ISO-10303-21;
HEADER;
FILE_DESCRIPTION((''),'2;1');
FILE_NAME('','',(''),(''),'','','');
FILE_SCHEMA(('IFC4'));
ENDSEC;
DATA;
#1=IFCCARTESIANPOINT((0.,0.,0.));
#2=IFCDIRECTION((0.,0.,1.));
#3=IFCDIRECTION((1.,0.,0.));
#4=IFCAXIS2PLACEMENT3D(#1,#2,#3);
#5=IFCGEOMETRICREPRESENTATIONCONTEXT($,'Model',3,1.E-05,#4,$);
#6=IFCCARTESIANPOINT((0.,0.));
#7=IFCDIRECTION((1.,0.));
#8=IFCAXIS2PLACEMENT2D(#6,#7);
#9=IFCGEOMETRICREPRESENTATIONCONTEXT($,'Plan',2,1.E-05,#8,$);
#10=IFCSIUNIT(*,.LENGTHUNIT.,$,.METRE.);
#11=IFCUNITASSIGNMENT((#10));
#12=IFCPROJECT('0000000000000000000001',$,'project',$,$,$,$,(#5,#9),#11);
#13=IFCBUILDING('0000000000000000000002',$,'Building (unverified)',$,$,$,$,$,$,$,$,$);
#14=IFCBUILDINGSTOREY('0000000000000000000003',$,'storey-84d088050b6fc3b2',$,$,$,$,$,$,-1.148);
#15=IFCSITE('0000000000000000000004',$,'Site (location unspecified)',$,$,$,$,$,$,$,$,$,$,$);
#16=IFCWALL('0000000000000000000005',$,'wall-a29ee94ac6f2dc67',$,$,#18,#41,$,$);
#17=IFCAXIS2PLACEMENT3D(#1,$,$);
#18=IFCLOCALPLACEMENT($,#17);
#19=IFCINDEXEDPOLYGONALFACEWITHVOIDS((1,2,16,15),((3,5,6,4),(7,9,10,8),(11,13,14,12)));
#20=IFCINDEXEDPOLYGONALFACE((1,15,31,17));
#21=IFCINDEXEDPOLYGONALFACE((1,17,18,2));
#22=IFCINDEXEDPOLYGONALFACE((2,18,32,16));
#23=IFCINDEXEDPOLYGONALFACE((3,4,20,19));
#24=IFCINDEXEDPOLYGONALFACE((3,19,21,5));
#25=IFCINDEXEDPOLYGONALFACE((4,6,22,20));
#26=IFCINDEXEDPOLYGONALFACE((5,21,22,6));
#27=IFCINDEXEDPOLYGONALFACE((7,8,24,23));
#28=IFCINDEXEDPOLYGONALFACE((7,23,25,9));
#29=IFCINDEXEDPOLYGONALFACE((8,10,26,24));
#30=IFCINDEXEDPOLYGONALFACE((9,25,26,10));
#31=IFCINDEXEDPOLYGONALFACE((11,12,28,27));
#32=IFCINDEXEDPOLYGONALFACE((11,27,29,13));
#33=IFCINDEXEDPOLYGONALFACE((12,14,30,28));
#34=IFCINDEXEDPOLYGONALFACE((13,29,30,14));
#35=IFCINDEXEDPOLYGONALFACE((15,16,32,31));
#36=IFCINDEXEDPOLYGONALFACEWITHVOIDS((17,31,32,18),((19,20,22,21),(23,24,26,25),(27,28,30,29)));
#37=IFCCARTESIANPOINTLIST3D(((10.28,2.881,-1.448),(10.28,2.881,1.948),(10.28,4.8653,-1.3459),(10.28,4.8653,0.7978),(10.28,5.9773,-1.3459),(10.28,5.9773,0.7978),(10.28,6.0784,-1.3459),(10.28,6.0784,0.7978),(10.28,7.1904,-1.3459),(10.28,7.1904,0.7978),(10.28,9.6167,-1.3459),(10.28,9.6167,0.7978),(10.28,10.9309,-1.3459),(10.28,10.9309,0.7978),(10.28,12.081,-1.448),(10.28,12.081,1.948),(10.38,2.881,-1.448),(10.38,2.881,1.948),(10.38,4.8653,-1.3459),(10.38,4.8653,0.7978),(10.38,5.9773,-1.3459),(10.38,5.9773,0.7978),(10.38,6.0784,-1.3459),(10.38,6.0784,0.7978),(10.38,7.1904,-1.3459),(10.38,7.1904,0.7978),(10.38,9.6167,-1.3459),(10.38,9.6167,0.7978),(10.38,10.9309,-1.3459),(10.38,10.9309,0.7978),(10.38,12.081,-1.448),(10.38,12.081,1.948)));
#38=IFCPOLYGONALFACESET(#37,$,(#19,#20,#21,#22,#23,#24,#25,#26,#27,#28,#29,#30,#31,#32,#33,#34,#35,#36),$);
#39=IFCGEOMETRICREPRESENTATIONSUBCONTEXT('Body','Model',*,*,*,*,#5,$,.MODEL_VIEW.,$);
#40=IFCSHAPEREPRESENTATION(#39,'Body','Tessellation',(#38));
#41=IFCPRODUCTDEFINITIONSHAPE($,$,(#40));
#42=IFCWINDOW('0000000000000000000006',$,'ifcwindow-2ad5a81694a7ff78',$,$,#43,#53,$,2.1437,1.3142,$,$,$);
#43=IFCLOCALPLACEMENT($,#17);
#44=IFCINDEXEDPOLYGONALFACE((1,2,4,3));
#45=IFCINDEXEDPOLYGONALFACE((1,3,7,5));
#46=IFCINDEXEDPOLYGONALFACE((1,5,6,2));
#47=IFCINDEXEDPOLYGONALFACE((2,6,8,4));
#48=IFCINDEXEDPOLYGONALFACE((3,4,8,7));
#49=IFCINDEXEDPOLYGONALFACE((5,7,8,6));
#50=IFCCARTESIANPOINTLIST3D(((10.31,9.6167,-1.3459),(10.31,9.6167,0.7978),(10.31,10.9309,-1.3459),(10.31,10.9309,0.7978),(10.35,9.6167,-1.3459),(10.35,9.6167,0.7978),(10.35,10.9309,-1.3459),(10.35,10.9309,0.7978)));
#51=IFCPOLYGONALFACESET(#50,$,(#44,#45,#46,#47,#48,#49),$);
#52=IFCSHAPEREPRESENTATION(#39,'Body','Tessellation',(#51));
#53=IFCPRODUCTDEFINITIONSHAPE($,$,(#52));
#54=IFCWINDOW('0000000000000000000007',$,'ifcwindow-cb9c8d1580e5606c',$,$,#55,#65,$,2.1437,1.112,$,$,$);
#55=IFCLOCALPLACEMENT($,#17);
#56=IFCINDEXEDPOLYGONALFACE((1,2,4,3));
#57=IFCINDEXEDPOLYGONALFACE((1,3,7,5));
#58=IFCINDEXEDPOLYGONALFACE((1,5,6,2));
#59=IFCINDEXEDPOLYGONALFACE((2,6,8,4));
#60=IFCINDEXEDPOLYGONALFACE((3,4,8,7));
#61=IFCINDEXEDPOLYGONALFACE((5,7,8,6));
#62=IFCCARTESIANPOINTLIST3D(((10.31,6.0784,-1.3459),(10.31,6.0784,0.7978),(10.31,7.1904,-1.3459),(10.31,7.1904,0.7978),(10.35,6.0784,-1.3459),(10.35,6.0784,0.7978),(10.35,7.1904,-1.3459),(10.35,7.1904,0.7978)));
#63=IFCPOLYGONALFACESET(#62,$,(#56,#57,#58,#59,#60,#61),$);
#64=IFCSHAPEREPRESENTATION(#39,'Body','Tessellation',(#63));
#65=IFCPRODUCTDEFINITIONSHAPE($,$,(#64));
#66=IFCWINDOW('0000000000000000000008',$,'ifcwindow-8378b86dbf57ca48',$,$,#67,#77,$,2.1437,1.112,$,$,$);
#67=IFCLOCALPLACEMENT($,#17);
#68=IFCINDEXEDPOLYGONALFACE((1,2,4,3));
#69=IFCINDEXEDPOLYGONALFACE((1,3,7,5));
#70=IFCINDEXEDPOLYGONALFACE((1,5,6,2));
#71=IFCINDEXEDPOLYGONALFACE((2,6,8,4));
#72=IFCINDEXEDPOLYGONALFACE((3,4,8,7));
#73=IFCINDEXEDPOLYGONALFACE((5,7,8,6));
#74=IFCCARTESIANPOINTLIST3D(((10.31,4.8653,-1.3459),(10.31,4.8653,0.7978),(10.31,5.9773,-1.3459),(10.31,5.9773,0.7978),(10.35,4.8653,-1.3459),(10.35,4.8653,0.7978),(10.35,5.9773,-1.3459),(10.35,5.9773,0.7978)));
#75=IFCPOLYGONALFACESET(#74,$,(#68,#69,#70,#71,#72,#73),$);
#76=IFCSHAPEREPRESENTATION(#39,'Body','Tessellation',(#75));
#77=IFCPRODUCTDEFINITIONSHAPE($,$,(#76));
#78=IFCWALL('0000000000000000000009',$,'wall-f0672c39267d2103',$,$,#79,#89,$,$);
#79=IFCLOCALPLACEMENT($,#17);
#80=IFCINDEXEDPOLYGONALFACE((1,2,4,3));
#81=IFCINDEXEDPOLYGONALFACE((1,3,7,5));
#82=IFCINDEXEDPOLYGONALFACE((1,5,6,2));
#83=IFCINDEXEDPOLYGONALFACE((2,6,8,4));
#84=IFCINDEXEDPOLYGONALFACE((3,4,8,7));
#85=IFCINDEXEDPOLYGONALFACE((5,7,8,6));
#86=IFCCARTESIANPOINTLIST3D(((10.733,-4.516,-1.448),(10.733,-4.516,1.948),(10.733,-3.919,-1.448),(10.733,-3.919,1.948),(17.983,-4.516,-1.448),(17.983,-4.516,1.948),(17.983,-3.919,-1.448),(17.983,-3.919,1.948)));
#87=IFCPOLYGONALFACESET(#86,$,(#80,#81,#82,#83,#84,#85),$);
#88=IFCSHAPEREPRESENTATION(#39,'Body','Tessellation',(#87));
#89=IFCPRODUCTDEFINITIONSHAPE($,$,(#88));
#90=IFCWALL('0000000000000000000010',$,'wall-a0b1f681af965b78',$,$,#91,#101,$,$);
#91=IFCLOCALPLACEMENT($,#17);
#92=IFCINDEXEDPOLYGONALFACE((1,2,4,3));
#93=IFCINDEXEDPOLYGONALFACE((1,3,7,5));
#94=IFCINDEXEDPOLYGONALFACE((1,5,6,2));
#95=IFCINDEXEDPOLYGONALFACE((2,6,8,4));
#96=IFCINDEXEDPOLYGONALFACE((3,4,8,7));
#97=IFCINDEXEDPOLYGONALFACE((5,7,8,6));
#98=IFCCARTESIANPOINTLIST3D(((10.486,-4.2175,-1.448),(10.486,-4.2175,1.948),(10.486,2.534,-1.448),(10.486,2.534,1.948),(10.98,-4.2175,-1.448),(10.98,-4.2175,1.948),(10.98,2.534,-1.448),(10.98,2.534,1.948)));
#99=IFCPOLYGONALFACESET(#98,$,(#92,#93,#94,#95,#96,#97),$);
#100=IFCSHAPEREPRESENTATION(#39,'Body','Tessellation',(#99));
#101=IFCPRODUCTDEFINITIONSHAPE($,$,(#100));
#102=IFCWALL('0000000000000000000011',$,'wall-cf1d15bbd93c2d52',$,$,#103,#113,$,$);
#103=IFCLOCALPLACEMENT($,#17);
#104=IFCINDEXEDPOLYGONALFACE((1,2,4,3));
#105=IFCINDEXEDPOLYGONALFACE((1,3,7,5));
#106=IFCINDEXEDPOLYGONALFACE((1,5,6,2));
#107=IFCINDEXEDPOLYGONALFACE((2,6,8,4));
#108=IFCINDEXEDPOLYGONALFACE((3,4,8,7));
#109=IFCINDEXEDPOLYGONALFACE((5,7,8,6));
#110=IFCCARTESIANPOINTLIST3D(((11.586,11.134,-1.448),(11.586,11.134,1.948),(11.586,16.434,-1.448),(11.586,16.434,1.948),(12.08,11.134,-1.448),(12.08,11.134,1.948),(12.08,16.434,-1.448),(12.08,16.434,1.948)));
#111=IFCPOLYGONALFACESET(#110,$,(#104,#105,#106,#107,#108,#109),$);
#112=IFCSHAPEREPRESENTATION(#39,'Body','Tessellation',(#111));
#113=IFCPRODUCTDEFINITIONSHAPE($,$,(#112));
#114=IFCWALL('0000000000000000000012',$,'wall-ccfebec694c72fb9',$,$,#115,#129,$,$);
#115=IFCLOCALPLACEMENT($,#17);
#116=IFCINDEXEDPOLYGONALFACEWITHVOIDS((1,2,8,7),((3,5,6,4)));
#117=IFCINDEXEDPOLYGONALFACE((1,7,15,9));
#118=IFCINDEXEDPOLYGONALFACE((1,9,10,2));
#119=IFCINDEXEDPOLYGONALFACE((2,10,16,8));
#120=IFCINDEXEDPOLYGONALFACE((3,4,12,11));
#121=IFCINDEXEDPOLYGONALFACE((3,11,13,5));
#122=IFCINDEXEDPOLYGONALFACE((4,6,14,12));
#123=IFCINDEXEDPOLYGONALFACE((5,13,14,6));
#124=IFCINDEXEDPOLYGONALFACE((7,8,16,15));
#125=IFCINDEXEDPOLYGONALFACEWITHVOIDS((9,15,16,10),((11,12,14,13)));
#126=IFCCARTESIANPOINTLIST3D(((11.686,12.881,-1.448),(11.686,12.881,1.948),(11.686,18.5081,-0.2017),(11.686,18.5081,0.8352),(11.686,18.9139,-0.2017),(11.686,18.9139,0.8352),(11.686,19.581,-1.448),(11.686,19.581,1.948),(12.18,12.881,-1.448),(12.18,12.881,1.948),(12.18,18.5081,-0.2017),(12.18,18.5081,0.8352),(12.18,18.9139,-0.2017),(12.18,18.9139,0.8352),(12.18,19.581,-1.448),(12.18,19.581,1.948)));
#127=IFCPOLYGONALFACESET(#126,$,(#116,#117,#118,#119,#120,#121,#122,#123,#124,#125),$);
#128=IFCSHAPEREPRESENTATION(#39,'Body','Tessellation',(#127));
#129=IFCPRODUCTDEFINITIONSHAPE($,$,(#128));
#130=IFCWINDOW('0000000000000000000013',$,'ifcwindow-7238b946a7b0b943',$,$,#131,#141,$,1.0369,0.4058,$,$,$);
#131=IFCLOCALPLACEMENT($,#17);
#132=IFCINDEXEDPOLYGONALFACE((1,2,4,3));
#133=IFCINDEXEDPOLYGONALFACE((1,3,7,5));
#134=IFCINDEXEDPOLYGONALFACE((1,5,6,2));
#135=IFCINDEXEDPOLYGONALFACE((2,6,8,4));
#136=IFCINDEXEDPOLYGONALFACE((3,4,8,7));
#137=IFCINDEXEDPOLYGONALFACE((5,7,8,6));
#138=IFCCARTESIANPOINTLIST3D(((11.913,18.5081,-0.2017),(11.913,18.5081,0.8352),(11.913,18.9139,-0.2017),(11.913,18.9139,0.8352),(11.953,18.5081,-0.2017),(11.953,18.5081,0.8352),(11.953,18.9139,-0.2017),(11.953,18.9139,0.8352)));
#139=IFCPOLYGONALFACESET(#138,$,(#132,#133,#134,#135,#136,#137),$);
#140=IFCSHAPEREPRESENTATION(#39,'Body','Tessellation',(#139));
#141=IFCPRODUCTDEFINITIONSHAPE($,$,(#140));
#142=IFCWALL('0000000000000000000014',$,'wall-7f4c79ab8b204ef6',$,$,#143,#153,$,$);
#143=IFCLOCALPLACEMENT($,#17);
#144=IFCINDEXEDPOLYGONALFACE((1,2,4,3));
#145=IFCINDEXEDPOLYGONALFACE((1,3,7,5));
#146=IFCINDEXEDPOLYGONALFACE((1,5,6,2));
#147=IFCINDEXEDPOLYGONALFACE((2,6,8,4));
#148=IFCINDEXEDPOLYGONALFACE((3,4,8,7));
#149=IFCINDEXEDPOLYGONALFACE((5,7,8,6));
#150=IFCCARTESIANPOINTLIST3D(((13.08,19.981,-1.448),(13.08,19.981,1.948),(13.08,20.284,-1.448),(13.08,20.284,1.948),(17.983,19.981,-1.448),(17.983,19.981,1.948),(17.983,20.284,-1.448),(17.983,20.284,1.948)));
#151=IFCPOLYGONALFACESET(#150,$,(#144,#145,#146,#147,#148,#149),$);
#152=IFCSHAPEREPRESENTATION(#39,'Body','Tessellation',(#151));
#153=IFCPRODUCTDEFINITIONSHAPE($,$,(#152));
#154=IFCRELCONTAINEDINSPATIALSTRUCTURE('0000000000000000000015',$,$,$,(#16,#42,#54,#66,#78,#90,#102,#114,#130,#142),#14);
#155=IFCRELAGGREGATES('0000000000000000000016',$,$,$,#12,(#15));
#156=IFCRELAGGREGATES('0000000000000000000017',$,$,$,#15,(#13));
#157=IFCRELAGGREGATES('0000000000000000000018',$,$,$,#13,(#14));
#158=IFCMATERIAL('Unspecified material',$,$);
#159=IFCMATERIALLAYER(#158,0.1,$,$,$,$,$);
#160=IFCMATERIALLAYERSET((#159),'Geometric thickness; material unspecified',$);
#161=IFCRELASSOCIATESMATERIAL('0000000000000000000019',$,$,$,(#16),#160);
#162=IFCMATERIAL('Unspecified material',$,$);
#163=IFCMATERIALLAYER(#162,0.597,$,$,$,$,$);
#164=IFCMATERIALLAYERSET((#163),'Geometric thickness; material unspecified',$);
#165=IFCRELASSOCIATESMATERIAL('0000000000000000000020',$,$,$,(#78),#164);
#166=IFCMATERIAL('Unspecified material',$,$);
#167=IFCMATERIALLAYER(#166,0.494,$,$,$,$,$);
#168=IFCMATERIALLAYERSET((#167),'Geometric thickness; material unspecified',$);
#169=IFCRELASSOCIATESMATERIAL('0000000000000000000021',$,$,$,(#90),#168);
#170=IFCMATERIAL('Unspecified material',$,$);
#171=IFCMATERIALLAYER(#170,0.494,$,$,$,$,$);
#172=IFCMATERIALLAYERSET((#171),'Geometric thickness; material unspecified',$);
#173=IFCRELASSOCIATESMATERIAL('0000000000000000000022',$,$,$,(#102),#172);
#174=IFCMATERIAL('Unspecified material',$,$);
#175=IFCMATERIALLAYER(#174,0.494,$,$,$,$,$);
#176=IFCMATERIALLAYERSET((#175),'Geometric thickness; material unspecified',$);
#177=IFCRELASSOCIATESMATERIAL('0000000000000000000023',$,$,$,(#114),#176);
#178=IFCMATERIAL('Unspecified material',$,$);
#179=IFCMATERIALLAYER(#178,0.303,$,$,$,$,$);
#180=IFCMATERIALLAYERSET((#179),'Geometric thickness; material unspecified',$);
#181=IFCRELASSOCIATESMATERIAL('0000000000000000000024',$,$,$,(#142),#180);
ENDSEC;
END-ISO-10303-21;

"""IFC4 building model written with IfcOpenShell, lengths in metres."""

from ifc_helpers import new_model, si_unit, frame, origin_with_axes, origin_2d_with_axis, place, context, subcontext, project, spatial, line, indexed_curve, outline, extrude, material, layer, layer_set, layer_usage, element, fill, save


model = new_model("IFC4")

# Units and contexts
model_context = context("Model", 3, precision=1e-05, world=origin_with_axes())
plan_context = context("Plan", 2, precision=1e-05, world=origin_2d_with_axis())
body_context = subcontext(model_context, "Body", "Model", "MODEL_VIEW")
ifc_project = project(units=[si_unit("LENGTHUNIT", "METRE")], contexts=[model_context, plan_context])

# Site, building, storey
site = spatial("IfcSite", under=ifc_project, Name="Site (location unspecified)")
building = spatial("IfcBuilding", under=site, Name="Building (unverified)")
storey = spatial("IfcBuildingStorey", under=building, Name="storey-84d088050b6fc3b2", Elevation=-1.148)

# Wall, openings, windows
ifc_material_1 = material(Name="Unspecified material")
ifc_layer_1 = layer(ifc_material_1, 0.1)
ifc_layer_set_1 = layer_set([ifc_layer_1], Name="Geometric thickness; material unspecified")
ifc_layer_usage_1 = layer_usage(ifc_layer_set_1, "AXIS2", "POSITIVE", -0.05)
wall_1_placement = place(None, frame((10.33, 12.081, -1.448), z_axis=(0.0, 0.0, 1.0), x_axis=(0.0, -1.0, 0.0)))
wall_1 = element("IfcWall", 1, at=wall_1_placement, inside=storey, material=ifc_layer_usage_1, Name="wall-a29ee94ac6f2dc67", context=body_context, shape_type="SweptSolid", body=[
    extrude(outline(indexed_curve([(0.0, 0.0), (0.0, 0.1), (9.2, 0.1), (9.2, 0.0), (0.0, 0.0)], self_intersect=False)), frame((0.0, -0.05, 0.0), z_axis=(0.0, 0.0, 1.0), x_axis=(1.0, 0.0, 0.0)), (0.0, 0.0, 1.0), 3.396),
])
opening_1_placement = place(wall_1_placement, frame((1.1501, -0.06, 0.1021), z_axis=(0.0, 0.0, 1.0), x_axis=(1.0, 0.0, 0.0)))
opening_1 = element("IfcOpeningElement", 2, at=opening_1_placement, cuts=wall_1, context=body_context, shape_type="SweptSolid", body=[
    extrude(outline(indexed_curve([(0.0, 0.0), (0.0, 0.12), (1.3142, 0.12), (1.3142, 0.0), (0.0, 0.0)], self_intersect=False)), origin_with_axes(), (0.0, 0.0, 1.0), 2.1437),
])
opening_2_placement = place(wall_1_placement, frame((4.8906, -0.06, 0.1021), z_axis=(0.0, 0.0, 1.0), x_axis=(1.0, 0.0, 0.0)))
opening_2 = element("IfcOpeningElement", 3, at=opening_2_placement, cuts=wall_1, context=body_context, shape_type="SweptSolid", body=[
    extrude(outline(indexed_curve([(0.0, 0.0), (0.0, 0.12), (1.112, 0.12), (1.112, 0.0), (0.0, 0.0)], self_intersect=False)), origin_with_axes(), (0.0, 0.0, 1.0), 2.1437),
])
opening_3_placement = place(wall_1_placement, frame((6.1037, -0.06, 0.1021), z_axis=(0.0, 0.0, 1.0), x_axis=(1.0, 0.0, 0.0)))
opening_3 = element("IfcOpeningElement", 4, at=opening_3_placement, cuts=wall_1, context=body_context, shape_type="SweptSolid", body=[
    extrude(outline(indexed_curve([(0.0, 0.0), (0.0, 0.12), (1.112, 0.12), (1.112, 0.0), (0.0, 0.0)], self_intersect=False)), origin_with_axes(), (0.0, 0.0, 1.0), 2.1437),
])
window_1_placement = place(None, frame((10.31, 10.9309, -1.3459), z_axis=(0.0, 0.0, 1.0), x_axis=(0.0, -1.0, 0.0)))
window_1 = element("IfcWindow", 5, at=window_1_placement, inside=storey, Name="ifcwindow-2ad5a81694a7ff78", OverallHeight=2.1437, OverallWidth=1.3142, context=body_context, shape_type="SweptSolid", body=[
    extrude(outline(indexed_curve([(0.0, 0.0), (0.0, 0.04), (1.3142, 0.04), (1.3142, 0.0), (0.0, 0.0)], self_intersect=False)), origin_with_axes(), (0.0, 0.0, 1.0), 2.1437),
])
fill(opening_1, window_1)
window_2_placement = place(None, frame((10.31, 7.1904, -1.3459), z_axis=(0.0, 0.0, 1.0), x_axis=(0.0, -1.0, 0.0)))
window_2 = element("IfcWindow", 6, at=window_2_placement, inside=storey, Name="ifcwindow-cb9c8d1580e5606c", OverallHeight=2.1437, OverallWidth=1.112, context=body_context, shape_type="SweptSolid", body=[
    extrude(outline(indexed_curve([(0.0, 0.0), (0.0, 0.04), (1.112, 0.04), (1.112, 0.0), (0.0, 0.0)], self_intersect=False)), origin_with_axes(), (0.0, 0.0, 1.0), 2.1437),
])
fill(opening_2, window_2)
window_3_placement = place(None, frame((10.31, 5.9773, -1.3459), z_axis=(0.0, 0.0, 1.0), x_axis=(0.0, -1.0, 0.0)))
window_3 = element("IfcWindow", 7, at=window_3_placement, inside=storey, Name="ifcwindow-8378b86dbf57ca48", OverallHeight=2.1437, OverallWidth=1.112, context=body_context, shape_type="SweptSolid", body=[
    extrude(outline(indexed_curve([(0.0, 0.0), (0.0, 0.04), (1.112, 0.04), (1.112, 0.0), (0.0, 0.0)], self_intersect=False)), origin_with_axes(), (0.0, 0.0, 1.0), 2.1437),
])
fill(opening_3, window_3)

# Walls
ifc_material_2 = material(Name="Unspecified material")
ifc_layer_2 = layer(ifc_material_2, 0.597)
ifc_layer_set_2 = layer_set([ifc_layer_2], Name="Geometric thickness; material unspecified")
ifc_layer_usage_2 = layer_usage(ifc_layer_set_2, "AXIS2", "POSITIVE", -0.2985)
wall_2_placement = place(None, frame((17.983, -4.2175, -1.448), z_axis=(0.0, 0.0, 1.0), x_axis=(-1.0, 0.0, 0.0)))
element("IfcWall", 8, at=wall_2_placement, inside=storey, material=ifc_layer_usage_2, Name="wall-f0672c39267d2103", context=body_context, shape_type="SweptSolid", body=[
    extrude(outline(indexed_curve([(0.0, 0.0), (0.0, 0.597), (7.25, 0.597), (7.25, 0.0), (0.0, 0.0)], self_intersect=False)), frame((0.0, -0.2985, 0.0), z_axis=(0.0, 0.0, 1.0), x_axis=(1.0, 0.0, 0.0)), (0.0, 0.0, 1.0), 3.396),
])
ifc_material_3 = material(Name="Unspecified material")
ifc_layer_3 = layer(ifc_material_3, 0.494)
ifc_layer_set_3 = layer_set([ifc_layer_3], Name="Geometric thickness; material unspecified")
ifc_layer_usage_3 = layer_usage(ifc_layer_set_3, "AXIS2", "POSITIVE", -0.247)
wall_3_placement = place(None, frame((10.733, -4.2175, -1.448), z_axis=(0.0, 0.0, 1.0), x_axis=(0.0, 1.0, 0.0)))
element("IfcWall", 9, at=wall_3_placement, inside=storey, material=ifc_layer_usage_3, Name="wall-a0b1f681af965b78", context=body_context, shape_type="SweptSolid", body=[
    extrude(outline(indexed_curve([(0.0, 0.0), (0.0, 0.494), (6.7515, 0.494), (6.7515, 0.0), (0.0, 0.0)], self_intersect=False)), frame((0.0, -0.247, 0.0), z_axis=(0.0, 0.0, 1.0), x_axis=(1.0, 0.0, 0.0)), (0.0, 0.0, 1.0), 3.396),
])
ifc_material_4 = material(Name="Unspecified material")
ifc_layer_4 = layer(ifc_material_4, 0.494)
ifc_layer_set_4 = layer_set([ifc_layer_4], Name="Geometric thickness; material unspecified")
ifc_layer_usage_4 = layer_usage(ifc_layer_set_4, "AXIS2", "POSITIVE", -0.247)
wall_4_placement = place(None, frame((11.833, 11.134, -1.448), z_axis=(0.0, 0.0, 1.0), x_axis=(0.0, 1.0, 0.0)))
element("IfcWall", 10, at=wall_4_placement, inside=storey, material=ifc_layer_usage_4, Name="wall-cf1d15bbd93c2d52", context=body_context, shape_type="SweptSolid", body=[
    extrude(outline(indexed_curve([(0.0, -0.247), (0.0, 0.247), (5.3, 0.247), (5.3, -0.247)], segments=[line(1, 2, 3, 4, 1)])), origin_with_axes(), (0.0, 0.0, 1.0), 3.396),
])

# Wall, opening, window
ifc_material_5 = material(Name="Unspecified material")
ifc_layer_5 = layer(ifc_material_5, 0.494)
ifc_layer_set_5 = layer_set([ifc_layer_5], Name="Geometric thickness; material unspecified")
ifc_layer_usage_5 = layer_usage(ifc_layer_set_5, "AXIS2", "POSITIVE", -0.247)
wall_5_placement = place(None, frame((11.933, 12.881, -1.448), z_axis=(0.0, 0.0, 1.0), x_axis=(0.0, 1.0, 0.0)))
wall_5 = element("IfcWall", 11, at=wall_5_placement, inside=storey, material=ifc_layer_usage_5, Name="wall-ccfebec694c72fb9", context=body_context, shape_type="SweptSolid", body=[
    extrude(outline(indexed_curve([(0.0, 0.0), (0.0, 0.494), (6.7, 0.494), (6.7, 0.0), (0.0, 0.0)], self_intersect=False)), frame((0.0, -0.247, 0.0), z_axis=(0.0, 0.0, 1.0), x_axis=(1.0, 0.0, 0.0)), (0.0, 0.0, 1.0), 3.396),
])
opening_4_placement = place(wall_5_placement, frame((5.6271, -0.257, 1.2463), z_axis=(0.0, 0.0, 1.0), x_axis=(1.0, 0.0, 0.0)))
opening_4 = element("IfcOpeningElement", 12, at=opening_4_placement, cuts=wall_5, context=body_context, shape_type="SweptSolid", body=[
    extrude(outline(indexed_curve([(0.0, 0.0), (0.0, 0.514), (0.4058, 0.514), (0.4058, 0.0), (0.0, 0.0)], self_intersect=False)), origin_with_axes(), (0.0, 0.0, 1.0), 1.0369),
])
window_4_placement = place(None, frame((11.953, 18.5081, -0.2017), z_axis=(0.0, 0.0, 1.0), x_axis=(0.0, 1.0, 0.0)))
window_4 = element("IfcWindow", 13, at=window_4_placement, inside=storey, Name="ifcwindow-7238b946a7b0b943", OverallHeight=1.0369, OverallWidth=0.4058, context=body_context, shape_type="SweptSolid", body=[
    extrude(outline(indexed_curve([(0.0, 0.0), (0.0, 0.04), (0.4058, 0.04), (0.4058, 0.0), (0.0, 0.0)], self_intersect=False)), origin_with_axes(), (0.0, 0.0, 1.0), 1.0369),
])
fill(opening_4, window_4)

# Wall
ifc_material_6 = material(Name="Unspecified material")
ifc_layer_6 = layer(ifc_material_6, 0.303)
ifc_layer_set_6 = layer_set([ifc_layer_6], Name="Geometric thickness; material unspecified")
ifc_layer_usage_6 = layer_usage(ifc_layer_set_6, "AXIS2", "POSITIVE", -0.1515)
wall_6_placement = place(None, frame((13.08, 20.1325, -1.448), z_axis=(0.0, 0.0, 1.0), x_axis=(1.0, 0.0, 0.0)))
element("IfcWall", 14, at=wall_6_placement, inside=storey, material=ifc_layer_usage_6, Name="wall-7f4c79ab8b204ef6", context=body_context, shape_type="SweptSolid", body=[
    extrude(outline(indexed_curve([(0.0, 0.0), (0.0, 0.303), (4.903, 0.303), (4.903, 0.0), (0.0, 0.0)], self_intersect=False)), frame((0.0, -0.1515, 0.0), z_axis=(0.0, 0.0, 1.0), x_axis=(1.0, 0.0, 0.0)), (0.0, 0.0, 1.0), 3.396),
])

save(model, "model.ifc")
